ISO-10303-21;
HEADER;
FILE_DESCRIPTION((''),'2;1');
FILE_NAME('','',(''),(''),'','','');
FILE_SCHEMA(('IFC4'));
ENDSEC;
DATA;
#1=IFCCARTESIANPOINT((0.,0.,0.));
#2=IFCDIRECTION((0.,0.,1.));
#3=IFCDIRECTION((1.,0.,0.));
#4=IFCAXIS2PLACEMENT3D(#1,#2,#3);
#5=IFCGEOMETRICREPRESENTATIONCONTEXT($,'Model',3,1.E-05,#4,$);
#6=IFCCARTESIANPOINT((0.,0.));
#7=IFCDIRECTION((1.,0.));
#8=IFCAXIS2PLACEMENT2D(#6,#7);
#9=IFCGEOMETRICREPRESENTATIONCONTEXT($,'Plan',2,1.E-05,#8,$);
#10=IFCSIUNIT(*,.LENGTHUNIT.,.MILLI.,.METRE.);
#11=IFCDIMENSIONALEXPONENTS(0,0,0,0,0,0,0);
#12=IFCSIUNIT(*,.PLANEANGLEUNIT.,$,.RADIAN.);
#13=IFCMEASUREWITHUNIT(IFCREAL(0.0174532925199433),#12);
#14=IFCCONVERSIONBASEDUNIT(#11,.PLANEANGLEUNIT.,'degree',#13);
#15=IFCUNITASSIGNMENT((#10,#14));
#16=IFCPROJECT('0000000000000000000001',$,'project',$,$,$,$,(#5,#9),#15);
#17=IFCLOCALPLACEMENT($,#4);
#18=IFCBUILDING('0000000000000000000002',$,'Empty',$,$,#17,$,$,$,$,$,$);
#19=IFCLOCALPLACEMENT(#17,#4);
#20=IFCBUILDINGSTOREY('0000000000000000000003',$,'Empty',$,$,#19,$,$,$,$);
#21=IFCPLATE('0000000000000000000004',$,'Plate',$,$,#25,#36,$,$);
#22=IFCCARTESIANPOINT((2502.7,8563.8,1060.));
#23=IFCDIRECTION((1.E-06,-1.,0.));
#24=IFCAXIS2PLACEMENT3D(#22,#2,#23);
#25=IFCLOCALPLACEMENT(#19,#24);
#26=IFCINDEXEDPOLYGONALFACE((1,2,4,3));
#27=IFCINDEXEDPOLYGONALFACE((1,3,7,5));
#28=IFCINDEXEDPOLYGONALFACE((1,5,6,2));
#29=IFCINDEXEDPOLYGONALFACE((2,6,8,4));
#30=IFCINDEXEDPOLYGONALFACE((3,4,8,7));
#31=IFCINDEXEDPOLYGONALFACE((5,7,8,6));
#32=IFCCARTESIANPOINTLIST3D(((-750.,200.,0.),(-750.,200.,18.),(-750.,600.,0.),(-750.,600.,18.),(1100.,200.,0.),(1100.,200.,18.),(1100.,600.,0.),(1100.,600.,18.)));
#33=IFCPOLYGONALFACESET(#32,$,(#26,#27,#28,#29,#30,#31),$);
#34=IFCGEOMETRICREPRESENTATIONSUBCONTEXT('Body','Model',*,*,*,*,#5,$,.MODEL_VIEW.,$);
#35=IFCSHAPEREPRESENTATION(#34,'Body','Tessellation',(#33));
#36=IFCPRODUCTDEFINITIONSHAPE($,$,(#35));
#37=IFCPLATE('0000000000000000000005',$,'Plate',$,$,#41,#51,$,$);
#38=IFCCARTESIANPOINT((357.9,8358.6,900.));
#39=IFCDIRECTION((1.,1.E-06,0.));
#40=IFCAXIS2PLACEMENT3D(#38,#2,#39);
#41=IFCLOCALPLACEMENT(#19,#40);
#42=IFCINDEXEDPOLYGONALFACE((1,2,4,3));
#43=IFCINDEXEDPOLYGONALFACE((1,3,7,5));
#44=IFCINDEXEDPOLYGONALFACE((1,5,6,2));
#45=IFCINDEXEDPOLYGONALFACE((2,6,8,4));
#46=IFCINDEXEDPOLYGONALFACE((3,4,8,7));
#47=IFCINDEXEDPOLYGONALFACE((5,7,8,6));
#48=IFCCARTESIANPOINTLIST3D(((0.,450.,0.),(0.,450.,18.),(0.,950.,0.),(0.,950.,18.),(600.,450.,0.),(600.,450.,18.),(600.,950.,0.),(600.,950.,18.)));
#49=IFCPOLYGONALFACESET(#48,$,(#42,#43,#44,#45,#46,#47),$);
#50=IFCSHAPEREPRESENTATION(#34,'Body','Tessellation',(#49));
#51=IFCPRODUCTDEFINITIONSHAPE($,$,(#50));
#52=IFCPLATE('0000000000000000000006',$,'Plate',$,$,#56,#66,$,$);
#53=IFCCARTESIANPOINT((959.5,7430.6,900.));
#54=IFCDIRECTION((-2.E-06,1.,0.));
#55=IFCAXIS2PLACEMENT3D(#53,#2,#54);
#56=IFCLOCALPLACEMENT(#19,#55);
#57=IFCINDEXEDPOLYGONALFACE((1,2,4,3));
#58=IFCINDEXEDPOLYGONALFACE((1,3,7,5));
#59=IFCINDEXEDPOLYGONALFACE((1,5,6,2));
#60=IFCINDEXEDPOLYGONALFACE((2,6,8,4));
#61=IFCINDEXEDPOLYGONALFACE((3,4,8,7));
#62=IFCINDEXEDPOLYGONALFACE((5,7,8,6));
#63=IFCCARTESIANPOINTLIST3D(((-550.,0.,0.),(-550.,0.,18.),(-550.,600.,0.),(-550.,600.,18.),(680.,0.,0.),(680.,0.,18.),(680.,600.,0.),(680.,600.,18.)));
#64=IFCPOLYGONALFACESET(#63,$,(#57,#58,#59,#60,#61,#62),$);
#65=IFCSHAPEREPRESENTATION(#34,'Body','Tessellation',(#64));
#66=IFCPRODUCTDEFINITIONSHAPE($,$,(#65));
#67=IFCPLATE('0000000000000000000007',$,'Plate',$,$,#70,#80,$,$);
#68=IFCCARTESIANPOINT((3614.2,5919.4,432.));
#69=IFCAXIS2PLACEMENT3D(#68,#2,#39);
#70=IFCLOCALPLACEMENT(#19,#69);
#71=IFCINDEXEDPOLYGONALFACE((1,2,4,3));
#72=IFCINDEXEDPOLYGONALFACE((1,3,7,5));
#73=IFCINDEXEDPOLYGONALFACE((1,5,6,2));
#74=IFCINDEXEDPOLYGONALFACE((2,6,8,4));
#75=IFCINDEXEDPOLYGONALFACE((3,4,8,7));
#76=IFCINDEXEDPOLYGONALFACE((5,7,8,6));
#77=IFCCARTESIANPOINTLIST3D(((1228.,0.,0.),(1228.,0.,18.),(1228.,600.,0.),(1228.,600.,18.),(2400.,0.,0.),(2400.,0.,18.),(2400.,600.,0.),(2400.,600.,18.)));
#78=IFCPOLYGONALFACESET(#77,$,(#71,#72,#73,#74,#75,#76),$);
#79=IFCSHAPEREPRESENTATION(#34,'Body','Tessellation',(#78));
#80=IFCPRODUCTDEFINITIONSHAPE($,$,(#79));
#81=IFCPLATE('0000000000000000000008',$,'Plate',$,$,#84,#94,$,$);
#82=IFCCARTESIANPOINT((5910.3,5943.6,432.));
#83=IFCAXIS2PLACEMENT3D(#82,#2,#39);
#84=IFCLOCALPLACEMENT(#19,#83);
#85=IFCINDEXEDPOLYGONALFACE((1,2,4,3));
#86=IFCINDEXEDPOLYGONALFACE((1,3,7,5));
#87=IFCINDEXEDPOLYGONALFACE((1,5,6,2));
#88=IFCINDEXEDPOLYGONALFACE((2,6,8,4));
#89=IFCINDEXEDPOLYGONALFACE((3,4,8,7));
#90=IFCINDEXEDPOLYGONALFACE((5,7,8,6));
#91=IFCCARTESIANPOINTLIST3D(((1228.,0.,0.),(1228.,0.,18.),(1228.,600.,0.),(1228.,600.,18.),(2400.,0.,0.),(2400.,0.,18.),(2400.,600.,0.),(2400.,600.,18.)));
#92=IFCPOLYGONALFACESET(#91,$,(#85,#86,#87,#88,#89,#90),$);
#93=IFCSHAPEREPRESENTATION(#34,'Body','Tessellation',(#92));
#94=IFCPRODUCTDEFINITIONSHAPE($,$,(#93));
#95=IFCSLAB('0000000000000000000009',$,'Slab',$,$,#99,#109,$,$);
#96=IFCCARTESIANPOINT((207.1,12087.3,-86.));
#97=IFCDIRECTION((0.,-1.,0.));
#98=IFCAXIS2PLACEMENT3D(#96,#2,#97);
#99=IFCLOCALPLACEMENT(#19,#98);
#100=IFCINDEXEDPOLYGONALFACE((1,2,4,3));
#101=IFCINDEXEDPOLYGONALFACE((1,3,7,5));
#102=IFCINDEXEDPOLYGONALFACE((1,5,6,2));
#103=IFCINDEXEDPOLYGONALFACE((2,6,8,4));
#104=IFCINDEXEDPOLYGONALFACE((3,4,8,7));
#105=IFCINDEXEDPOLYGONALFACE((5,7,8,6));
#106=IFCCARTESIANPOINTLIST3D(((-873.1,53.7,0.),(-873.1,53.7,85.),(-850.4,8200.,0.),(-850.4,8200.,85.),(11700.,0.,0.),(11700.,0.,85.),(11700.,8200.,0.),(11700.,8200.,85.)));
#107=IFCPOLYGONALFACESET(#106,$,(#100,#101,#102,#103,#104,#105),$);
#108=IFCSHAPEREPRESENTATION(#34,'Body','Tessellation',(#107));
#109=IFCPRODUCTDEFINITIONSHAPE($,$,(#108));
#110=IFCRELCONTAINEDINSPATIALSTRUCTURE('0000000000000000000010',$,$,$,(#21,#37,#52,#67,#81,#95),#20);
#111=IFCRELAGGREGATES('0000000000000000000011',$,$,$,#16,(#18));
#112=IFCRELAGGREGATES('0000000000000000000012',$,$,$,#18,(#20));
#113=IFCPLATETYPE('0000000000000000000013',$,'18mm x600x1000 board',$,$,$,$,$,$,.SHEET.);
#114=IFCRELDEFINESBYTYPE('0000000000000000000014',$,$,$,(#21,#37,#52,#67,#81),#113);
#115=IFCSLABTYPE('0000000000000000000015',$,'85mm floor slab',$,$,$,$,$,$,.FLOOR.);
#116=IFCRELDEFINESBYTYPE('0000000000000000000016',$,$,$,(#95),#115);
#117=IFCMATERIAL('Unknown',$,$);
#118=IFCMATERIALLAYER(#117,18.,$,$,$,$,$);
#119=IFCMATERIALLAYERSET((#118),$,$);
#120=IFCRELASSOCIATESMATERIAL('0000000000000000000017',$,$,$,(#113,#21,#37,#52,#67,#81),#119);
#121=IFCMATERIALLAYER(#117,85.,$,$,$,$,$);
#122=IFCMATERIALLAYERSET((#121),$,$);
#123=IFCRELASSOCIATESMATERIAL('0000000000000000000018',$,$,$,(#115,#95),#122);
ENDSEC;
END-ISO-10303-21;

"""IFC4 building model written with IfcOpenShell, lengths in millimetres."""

from ifc_helpers import new_model, entity, si_unit, converted_unit, frame, origin_with_axes, origin_2d_with_axis, place, context, subcontext, project, spatial, line, indexed_curve, outline, extrude, material, layer, layer_set, layer_usage, type_object, element, save


model = new_model("IFC4")

# Units and contexts
model_context = context("Model", 3, precision=1e-05, world=origin_with_axes())
plan_context = context("Plan", 2, precision=1e-05, world=origin_2d_with_axis())
body_context = subcontext(model_context, "Body", "Model", "MODEL_VIEW")
ifc_project = project(units=[si_unit("LENGTHUNIT", "METRE", prefix="MILLI"), converted_unit("PLANEANGLEUNIT", "degree", entity("IfcReal", 0.0174532925199433), si_unit("PLANEANGLEUNIT", "RADIAN"), dimensions=[0, 0, 0, 0, 0, 0, 0])], contexts=[model_context, plan_context])

# Building, storey
building_placement = place(None, origin_with_axes())
building = spatial("IfcBuilding", under=ifc_project, at=building_placement, Name="Empty")
storey_placement = place(building_placement, origin_with_axes())
storey = spatial("IfcBuildingStorey", under=building, at=storey_placement, Name="Empty")

# Shared definitions
ifc_material_1 = material(Name="Unknown")

# Plates
ifc_layer_1 = layer(ifc_material_1, 18.0)
ifc_layer_set_1 = layer_set([ifc_layer_1])
ifc_layer_usage_1 = layer_usage(ifc_layer_set_1, "AXIS3", "POSITIVE", 0.0)
plate_type = type_object("IfcPlateType", Name="18mm x600x1000 board", PredefinedType="SHEET", material=ifc_layer_set_1)
plate_1_placement = place(storey_placement, frame((2502.7, 8563.8, 1060.0), z_axis=(0.0, 0.0, 1.0), x_axis=(0.000001, -1.0, 0.0)))
element("IfcPlate", 1, at=plate_1_placement, inside=storey, type_object=plate_type, material=ifc_layer_usage_1, Name="Plate", context=body_context, shape_type="SweptSolid", body=[
    extrude(outline(indexed_curve([(-750.0, 200.0), (-750.0, 600.0), (1100.0, 600.0), (1100.0, 200.0)], segments=[line(3, 2), line(2, 1), line(1, 4), line(4, 3)], self_intersect=False)), None, (0.0, 0.0, 1.0), 18.0),
])
ifc_layer_usage_2 = layer_usage(ifc_layer_set_1, "AXIS3", "POSITIVE", 0.0)
plate_2_placement = place(storey_placement, frame((357.9, 8358.6, 900.0), z_axis=(0.0, 0.0, 1.0), x_axis=(1.0, 0.000001, 0.0)))
element("IfcPlate", 2, at=plate_2_placement, inside=storey, type_object=plate_type, material=ifc_layer_usage_2, Name="Plate", context=body_context, shape_type="SweptSolid", body=[
    extrude(outline(indexed_curve([(0.0, 950.0), (0.0, 450.0), (600.0, 450.0), (600.0, 950.0)], segments=[line(3, 2), line(2, 1), line(1, 4), line(4, 3)], self_intersect=False)), None, (0.0, 0.0, 1.0), 18.0),
])
ifc_layer_usage_3 = layer_usage(ifc_layer_set_1, "AXIS3", "POSITIVE", 0.0)
plate_3_placement = place(storey_placement, frame((959.5, 7430.6, 900.0), z_axis=(0.0, 0.0, 1.0), x_axis=(-0.000002, 1.0, 0.0)))
element("IfcPlate", 3, at=plate_3_placement, inside=storey, type_object=plate_type, material=ifc_layer_usage_3, Name="Plate", context=body_context, shape_type="SweptSolid", body=[
    extrude(outline(indexed_curve([(-550.0, 600.0), (-550.0, 0.0), (680.0, 0.0), (680.0, 600.0)], segments=[line(3, 2), line(2, 1), line(1, 4), line(4, 3)], self_intersect=False)), None, (0.0, 0.0, 1.0), 18.0),
])
ifc_layer_usage_4 = layer_usage(ifc_layer_set_1, "AXIS3", "POSITIVE", 0.0)
plate_4_placement = place(storey_placement, frame((3614.2, 5919.4, 432.0), z_axis=(0.0, 0.0, 1.0), x_axis=(1.0, 0.000001, 0.0)))
element("IfcPlate", 4, at=plate_4_placement, inside=storey, type_object=plate_type, material=ifc_layer_usage_4, Name="Plate", context=body_context, shape_type="SweptSolid", body=[
    extrude(outline(indexed_curve([(1228.0, 0.0), (1228.0, 600.0), (2400.0, 600.0), (2400.0, 0.0)], segments=[line(3, 2), line(2, 1), line(1, 4), line(4, 3)], self_intersect=False)), None, (0.0, 0.0, 1.0), 18.0),
])
ifc_layer_usage_5 = layer_usage(ifc_layer_set_1, "AXIS3", "POSITIVE", 0.0)
plate_5_placement = place(storey_placement, frame((5910.3, 5943.6, 432.0), z_axis=(0.0, 0.0, 1.0), x_axis=(1.0, 0.000001, 0.0)))
element("IfcPlate", 5, at=plate_5_placement, inside=storey, type_object=plate_type, material=ifc_layer_usage_5, Name="Plate", context=body_context, shape_type="SweptSolid", body=[
    extrude(outline(indexed_curve([(1228.0, 0.0), (1228.0, 600.0), (2400.0, 600.0), (2400.0, 0.0)], segments=[line(3, 2), line(2, 1), line(1, 4), line(4, 3)], self_intersect=False)), None, (0.0, 0.0, 1.0), 18.0),
])

# Slab
ifc_layer_2 = layer(ifc_material_1, 85.0)
ifc_layer_set_2 = layer_set([ifc_layer_2])
ifc_layer_usage_6 = layer_usage(ifc_layer_set_2, "AXIS3", "POSITIVE", 0.0)
slab_type = type_object("IfcSlabType", Name="85mm floor slab", PredefinedType="FLOOR", material=ifc_layer_set_2)
slab_placement = place(storey_placement, frame((207.1, 12087.3, -86.0), z_axis=(0.0, 0.0, 1.0), x_axis=(0.0, -1.0, 0.0)))
element("IfcSlab", 6, at=slab_placement, inside=storey, type_object=slab_type, material=ifc_layer_usage_6, Name="Slab", context=body_context, shape_type="SweptSolid", body=[
    extrude(outline(indexed_curve([(11700.0, 0.0), (-873.1, 53.7), (-850.4, 8200.0), (11700.0, 8200.0)], segments=[line(4, 1), line(1, 2), line(2, 3), line(3, 4)], self_intersect=False)), None, (0.0, 0.0, 1.0), 85.0),
])

save(model, "model.ifc")
